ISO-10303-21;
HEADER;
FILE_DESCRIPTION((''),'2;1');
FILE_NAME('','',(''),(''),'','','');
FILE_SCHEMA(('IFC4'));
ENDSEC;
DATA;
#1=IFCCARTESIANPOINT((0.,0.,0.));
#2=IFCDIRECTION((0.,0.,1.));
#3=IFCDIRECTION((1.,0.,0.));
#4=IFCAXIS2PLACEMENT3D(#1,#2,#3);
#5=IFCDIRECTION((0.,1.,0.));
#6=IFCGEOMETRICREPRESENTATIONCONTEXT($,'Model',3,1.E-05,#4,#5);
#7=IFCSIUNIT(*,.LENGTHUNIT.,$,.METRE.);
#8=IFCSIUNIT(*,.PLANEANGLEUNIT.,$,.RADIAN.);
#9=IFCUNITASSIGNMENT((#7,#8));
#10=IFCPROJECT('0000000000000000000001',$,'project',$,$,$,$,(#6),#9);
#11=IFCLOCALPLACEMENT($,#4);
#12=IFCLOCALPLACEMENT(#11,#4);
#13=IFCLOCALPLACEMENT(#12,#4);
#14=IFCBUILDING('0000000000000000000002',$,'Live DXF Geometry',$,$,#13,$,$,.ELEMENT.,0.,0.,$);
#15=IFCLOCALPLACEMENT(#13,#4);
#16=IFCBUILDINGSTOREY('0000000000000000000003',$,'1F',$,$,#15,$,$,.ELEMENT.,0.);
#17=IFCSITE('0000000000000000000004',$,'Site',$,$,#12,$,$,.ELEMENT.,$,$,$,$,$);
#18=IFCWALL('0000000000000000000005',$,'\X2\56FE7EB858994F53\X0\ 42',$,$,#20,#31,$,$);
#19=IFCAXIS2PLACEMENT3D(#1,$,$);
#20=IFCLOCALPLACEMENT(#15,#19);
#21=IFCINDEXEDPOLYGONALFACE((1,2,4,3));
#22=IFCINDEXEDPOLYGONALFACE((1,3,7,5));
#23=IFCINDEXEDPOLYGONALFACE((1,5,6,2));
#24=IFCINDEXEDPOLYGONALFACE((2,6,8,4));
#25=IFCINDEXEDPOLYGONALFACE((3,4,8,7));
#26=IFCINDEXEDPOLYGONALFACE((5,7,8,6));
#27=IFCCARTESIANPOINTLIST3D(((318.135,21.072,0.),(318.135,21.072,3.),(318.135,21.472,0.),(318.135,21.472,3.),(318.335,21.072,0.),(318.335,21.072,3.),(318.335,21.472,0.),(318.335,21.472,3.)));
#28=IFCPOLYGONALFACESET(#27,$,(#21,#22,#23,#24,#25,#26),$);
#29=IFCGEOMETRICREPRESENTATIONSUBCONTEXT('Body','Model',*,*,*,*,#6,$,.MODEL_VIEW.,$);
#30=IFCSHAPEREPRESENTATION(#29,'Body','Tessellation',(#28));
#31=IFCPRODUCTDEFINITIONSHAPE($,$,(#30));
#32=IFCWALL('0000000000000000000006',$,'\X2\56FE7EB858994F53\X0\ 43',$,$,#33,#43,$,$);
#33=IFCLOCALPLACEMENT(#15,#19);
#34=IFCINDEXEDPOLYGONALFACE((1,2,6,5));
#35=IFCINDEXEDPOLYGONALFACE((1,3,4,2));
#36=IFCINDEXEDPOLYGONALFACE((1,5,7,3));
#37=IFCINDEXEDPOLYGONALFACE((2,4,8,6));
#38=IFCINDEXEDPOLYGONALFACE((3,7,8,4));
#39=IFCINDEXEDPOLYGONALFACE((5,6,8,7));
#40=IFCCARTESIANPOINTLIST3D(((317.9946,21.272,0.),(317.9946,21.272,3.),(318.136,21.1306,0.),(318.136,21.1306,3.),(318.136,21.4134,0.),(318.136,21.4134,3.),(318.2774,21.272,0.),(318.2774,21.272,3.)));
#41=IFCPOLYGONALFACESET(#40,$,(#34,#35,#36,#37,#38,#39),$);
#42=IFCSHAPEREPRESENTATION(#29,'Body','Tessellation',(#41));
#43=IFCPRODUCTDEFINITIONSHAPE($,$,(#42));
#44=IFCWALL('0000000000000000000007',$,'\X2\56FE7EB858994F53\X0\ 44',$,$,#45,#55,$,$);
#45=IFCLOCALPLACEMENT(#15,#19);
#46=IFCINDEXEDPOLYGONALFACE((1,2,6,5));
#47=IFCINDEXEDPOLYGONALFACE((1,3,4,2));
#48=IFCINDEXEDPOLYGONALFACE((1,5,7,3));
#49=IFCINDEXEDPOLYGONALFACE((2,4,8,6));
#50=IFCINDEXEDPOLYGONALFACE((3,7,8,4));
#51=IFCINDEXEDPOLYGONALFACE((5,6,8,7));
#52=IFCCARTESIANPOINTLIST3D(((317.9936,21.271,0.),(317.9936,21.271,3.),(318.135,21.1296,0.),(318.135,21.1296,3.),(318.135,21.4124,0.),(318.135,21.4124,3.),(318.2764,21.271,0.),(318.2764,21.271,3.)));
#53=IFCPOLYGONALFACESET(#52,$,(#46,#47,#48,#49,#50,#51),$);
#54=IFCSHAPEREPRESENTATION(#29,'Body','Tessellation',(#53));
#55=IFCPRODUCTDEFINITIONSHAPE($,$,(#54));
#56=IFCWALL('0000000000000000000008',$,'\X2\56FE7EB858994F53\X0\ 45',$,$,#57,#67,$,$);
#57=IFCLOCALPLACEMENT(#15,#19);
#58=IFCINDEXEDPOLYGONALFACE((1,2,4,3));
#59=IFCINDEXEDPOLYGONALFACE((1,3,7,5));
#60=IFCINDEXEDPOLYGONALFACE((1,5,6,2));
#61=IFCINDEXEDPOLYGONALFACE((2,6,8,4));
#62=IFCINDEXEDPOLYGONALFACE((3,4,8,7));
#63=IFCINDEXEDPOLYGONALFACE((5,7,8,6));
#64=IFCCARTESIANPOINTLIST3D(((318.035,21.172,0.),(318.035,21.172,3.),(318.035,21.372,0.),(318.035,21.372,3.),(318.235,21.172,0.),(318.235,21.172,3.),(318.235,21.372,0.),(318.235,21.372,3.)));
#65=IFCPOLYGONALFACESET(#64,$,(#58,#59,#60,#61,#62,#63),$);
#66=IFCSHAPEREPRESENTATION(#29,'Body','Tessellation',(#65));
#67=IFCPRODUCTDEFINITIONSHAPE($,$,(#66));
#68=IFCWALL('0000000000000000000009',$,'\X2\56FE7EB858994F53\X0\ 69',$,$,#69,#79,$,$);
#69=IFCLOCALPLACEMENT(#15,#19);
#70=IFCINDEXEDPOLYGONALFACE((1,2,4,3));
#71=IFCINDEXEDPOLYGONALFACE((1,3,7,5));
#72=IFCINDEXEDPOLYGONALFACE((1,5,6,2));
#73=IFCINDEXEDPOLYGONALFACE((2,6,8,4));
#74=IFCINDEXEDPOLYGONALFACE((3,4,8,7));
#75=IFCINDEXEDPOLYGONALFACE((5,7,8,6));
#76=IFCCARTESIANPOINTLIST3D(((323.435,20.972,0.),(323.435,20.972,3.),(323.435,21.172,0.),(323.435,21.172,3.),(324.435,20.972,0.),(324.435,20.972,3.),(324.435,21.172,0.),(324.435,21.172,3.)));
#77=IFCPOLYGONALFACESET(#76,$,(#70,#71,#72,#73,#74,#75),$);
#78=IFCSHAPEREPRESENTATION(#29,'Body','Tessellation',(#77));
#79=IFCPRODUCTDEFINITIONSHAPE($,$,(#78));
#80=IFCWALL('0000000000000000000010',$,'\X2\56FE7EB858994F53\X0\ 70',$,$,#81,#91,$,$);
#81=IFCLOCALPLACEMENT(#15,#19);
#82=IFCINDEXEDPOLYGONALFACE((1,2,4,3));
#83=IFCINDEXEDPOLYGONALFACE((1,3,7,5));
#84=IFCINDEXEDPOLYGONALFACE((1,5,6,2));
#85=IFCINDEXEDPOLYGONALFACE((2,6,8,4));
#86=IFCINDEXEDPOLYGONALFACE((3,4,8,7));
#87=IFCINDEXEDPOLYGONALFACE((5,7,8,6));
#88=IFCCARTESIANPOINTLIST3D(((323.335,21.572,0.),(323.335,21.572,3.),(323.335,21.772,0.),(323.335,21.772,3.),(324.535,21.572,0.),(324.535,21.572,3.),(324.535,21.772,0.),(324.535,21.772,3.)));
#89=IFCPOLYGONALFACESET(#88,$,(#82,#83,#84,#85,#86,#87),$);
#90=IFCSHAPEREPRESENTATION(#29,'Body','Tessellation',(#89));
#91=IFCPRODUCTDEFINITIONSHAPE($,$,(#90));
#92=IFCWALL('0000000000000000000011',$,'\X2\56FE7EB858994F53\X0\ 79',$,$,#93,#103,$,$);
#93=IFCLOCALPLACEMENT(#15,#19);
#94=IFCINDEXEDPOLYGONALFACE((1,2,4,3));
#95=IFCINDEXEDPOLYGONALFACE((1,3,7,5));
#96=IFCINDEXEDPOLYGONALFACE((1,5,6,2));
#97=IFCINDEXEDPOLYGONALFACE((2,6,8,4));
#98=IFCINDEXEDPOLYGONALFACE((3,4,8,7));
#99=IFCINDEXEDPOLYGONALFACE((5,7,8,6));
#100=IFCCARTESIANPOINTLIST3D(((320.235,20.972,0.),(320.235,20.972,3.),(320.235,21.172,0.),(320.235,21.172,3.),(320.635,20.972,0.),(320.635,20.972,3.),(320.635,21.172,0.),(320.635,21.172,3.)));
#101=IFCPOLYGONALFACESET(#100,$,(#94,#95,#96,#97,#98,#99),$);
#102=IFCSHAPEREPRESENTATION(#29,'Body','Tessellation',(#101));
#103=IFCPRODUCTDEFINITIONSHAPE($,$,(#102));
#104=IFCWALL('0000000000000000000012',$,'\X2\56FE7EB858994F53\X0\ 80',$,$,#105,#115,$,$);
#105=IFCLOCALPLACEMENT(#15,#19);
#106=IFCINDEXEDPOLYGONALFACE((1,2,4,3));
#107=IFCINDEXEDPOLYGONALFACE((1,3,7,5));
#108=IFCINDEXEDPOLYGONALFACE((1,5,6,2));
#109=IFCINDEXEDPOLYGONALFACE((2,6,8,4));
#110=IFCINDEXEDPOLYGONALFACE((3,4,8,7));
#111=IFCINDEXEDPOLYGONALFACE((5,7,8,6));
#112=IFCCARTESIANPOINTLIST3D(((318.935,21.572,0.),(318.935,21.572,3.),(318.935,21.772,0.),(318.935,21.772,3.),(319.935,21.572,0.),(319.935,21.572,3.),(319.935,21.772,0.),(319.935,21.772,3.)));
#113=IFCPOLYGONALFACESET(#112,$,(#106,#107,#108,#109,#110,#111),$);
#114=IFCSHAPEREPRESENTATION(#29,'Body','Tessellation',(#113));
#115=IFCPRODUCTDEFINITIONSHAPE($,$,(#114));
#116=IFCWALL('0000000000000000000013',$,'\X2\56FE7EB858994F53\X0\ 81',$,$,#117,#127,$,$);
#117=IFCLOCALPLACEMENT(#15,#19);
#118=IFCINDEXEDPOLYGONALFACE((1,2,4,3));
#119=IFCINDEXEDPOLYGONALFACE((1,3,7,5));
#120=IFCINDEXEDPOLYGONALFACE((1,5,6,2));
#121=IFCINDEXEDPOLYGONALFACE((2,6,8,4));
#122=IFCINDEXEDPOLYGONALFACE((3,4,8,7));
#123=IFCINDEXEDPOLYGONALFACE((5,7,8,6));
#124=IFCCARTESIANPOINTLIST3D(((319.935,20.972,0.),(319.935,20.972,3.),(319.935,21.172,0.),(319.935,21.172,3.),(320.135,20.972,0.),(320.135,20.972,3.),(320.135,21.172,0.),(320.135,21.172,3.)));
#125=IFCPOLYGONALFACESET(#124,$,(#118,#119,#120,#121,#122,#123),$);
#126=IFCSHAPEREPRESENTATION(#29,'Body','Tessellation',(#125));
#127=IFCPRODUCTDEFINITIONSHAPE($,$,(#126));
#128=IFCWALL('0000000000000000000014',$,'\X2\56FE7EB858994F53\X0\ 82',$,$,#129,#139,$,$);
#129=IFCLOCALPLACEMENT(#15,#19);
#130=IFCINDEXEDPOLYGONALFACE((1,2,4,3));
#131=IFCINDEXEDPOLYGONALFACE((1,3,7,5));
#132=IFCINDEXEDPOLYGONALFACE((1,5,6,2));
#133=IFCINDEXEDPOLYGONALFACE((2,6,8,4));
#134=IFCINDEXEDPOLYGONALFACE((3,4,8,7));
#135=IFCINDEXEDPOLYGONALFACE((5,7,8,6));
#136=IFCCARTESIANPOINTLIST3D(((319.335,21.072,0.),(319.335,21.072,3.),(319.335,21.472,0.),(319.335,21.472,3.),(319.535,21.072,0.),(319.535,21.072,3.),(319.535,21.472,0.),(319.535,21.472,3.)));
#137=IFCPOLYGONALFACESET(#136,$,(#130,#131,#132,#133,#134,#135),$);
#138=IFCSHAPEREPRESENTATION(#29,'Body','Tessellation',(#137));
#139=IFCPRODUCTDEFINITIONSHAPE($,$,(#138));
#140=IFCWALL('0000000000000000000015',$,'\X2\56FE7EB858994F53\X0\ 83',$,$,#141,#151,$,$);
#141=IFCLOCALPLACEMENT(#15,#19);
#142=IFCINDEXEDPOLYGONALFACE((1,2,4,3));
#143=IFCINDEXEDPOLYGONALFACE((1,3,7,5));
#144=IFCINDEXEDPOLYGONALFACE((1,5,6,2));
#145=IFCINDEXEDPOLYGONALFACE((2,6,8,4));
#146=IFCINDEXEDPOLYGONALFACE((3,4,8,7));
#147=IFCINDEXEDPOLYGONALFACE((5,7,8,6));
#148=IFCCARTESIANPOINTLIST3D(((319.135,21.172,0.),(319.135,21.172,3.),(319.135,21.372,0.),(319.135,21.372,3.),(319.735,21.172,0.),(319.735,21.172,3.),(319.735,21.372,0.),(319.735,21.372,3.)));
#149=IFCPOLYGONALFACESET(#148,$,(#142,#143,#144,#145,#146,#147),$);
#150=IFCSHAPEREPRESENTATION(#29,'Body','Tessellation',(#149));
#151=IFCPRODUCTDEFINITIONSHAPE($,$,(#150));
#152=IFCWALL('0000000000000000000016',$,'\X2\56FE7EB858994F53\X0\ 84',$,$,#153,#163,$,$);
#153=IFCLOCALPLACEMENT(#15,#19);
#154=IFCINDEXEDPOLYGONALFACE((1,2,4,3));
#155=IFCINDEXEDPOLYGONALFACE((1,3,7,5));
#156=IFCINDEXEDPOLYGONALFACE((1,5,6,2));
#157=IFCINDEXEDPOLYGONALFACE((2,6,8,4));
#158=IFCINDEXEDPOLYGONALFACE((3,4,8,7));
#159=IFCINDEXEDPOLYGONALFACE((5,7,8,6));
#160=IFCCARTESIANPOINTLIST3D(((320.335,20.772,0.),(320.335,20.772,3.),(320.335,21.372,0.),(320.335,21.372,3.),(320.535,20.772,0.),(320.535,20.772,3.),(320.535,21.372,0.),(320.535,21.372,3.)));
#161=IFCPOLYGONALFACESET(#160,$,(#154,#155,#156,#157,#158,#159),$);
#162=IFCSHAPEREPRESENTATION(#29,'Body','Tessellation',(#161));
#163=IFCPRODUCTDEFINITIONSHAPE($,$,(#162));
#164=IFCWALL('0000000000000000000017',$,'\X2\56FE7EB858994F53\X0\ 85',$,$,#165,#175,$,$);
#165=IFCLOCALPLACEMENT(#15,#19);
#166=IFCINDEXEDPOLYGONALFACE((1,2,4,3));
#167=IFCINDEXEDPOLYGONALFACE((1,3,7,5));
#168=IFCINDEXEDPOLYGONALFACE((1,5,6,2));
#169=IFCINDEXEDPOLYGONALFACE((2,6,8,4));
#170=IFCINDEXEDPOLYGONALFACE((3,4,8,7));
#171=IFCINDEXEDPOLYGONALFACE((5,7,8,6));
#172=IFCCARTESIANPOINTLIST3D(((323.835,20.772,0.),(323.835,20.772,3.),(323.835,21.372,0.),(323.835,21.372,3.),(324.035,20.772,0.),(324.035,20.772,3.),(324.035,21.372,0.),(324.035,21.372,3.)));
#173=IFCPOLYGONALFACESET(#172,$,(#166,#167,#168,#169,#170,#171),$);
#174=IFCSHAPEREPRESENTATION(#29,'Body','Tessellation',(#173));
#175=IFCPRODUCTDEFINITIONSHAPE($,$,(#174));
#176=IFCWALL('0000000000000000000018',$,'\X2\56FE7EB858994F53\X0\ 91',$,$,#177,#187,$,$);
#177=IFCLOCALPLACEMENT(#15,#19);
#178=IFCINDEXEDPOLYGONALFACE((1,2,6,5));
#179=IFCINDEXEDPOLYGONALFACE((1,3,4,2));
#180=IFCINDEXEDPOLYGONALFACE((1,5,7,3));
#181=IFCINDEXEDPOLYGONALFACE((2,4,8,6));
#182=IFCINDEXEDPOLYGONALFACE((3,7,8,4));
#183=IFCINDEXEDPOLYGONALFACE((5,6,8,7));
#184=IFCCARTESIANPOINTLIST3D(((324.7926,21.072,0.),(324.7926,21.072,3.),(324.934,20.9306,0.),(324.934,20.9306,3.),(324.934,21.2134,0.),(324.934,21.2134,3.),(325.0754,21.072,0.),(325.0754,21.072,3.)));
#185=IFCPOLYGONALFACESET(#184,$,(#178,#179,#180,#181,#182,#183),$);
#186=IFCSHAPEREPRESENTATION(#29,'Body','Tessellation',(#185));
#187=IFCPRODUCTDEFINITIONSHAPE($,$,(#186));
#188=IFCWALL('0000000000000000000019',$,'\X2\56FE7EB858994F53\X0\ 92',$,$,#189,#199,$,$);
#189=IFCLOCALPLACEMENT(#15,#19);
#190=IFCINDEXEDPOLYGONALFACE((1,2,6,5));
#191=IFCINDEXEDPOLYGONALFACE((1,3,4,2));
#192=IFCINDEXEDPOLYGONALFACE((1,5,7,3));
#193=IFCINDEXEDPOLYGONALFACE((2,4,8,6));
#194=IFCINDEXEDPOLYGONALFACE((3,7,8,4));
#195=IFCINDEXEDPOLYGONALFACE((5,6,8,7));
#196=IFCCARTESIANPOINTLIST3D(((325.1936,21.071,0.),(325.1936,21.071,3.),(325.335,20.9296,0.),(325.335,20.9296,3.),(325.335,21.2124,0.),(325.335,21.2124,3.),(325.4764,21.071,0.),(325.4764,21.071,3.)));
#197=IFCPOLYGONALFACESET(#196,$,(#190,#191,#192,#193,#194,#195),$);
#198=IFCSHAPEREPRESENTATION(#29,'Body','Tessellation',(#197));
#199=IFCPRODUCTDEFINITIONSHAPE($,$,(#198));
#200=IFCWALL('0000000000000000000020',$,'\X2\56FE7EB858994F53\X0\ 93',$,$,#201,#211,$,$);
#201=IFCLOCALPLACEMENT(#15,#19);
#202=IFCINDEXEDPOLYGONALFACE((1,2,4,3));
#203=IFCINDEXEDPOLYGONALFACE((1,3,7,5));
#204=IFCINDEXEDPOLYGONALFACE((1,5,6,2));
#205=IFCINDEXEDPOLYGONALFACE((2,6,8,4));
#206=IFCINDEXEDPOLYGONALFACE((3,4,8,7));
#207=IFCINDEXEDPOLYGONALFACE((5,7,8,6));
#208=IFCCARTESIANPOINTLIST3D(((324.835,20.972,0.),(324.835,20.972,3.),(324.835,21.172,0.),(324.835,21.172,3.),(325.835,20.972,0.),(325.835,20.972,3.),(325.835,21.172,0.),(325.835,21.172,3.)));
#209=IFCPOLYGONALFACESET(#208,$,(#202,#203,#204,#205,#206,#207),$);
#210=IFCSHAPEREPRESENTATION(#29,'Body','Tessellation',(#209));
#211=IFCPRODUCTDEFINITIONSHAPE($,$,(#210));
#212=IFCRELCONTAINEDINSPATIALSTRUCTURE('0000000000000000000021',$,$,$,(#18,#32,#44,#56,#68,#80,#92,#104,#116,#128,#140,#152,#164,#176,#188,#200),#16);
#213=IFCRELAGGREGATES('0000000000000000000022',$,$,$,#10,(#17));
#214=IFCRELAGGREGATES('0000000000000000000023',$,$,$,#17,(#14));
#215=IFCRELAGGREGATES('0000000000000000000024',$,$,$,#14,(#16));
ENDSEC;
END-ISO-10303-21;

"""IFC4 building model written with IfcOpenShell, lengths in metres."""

from ifc_helpers import new_model, si_unit, direction, frame, frame_2d, origin_with_axes, place, context, subcontext, project, spatial, rectangle, extrude, element, save


model = new_model("IFC4")

# Units and contexts
model_context = context("Model", 3, precision=1e-05, world=origin_with_axes(), true_north=direction((0.0, 1.0, 0.0)))
body_context = subcontext(model_context, "Body", "Model", "MODEL_VIEW")
ifc_project = project(units=[si_unit("LENGTHUNIT", "METRE"), si_unit("PLANEANGLEUNIT", "RADIAN")], contexts=[model_context])

# Site, building, storey
placement = place(None, origin_with_axes())
site_placement = place(placement, origin_with_axes())
site = spatial("IfcSite", under=ifc_project, at=site_placement, Name="Site", CompositionType="ELEMENT")
building_placement = place(site_placement, origin_with_axes())
building = spatial("IfcBuilding", under=site, at=building_placement, Name="Live DXF Geometry", CompositionType="ELEMENT", ElevationOfRefHeight=0.0, ElevationOfTerrain=0.0)
storey_placement = place(building_placement, origin_with_axes())
storey = spatial("IfcBuildingStorey", under=building, at=storey_placement, Name="1F", CompositionType="ELEMENT", Elevation=0.0)

# Walls
wall_1_placement = place(storey_placement, frame((318.235, 21.272, 0.0), z_axis=(0.0, 0.0, 1.0), x_axis=(0.0, 1.0, 0.0)))
element("IfcWall", 1, at=wall_1_placement, inside=storey, Name="图纸墙体 42", context=body_context, shape_type="SweptSolid", body=[
    extrude(rectangle(XDim=0.4, YDim=0.2, at=frame_2d((0.0, 0.0), x_axis=(1.0, 0.0, 0.0))), frame((0.0, 0.0, 0.0), z_axis=(0.0, 0.0, 1.0)), (0.0, 0.0, 1.0), 3.0),
])
for number, where, z_axis, x_axis, name in (
    (2, (318.136, 21.272, 0.0), (0.0, 0.0, 1.0), (-0.707107, -0.707107, 0.0), "图纸墙体 43"),
    (3, (318.135, 21.271, 0.0), (0.0, 0.0, 1.0), (0.707107, 0.707107, 0.0), "图纸墙体 44"),
    (4, (318.135, 21.272, 0.0), (0.0, 0.0, 1.0), (1.0, 0.0, 0.0), "图纸墙体 45"),
):
    element("IfcWall", number, at=place(storey_placement, frame(where, z_axis=z_axis, x_axis=x_axis)), inside=storey, Name=name, context=body_context, shape_type="SweptSolid", body=[
        extrude(rectangle(XDim=0.2, YDim=0.2, at=frame_2d((0.0, 0.0), x_axis=(1.0, 0.0, 0.0))), frame((0.0, 0.0, 0.0), z_axis=(0.0, 0.0, 1.0)), (0.0, 0.0, 1.0), 3.0),
    ])
wall_2_placement = place(storey_placement, frame((323.935, 21.072, 0.0), z_axis=(0.0, 0.0, 1.0), x_axis=(1.0, 0.0, 0.0)))
element("IfcWall", 5, at=wall_2_placement, inside=storey, Name="图纸墙体 69", context=body_context, shape_type="SweptSolid", body=[
    extrude(rectangle(XDim=1.0, YDim=0.2, at=frame_2d((0.0, 0.0), x_axis=(1.0, 0.0, 0.0))), frame((0.0, 0.0, 0.0), z_axis=(0.0, 0.0, 1.0)), (0.0, 0.0, 1.0), 3.0),
])
wall_3_placement = place(storey_placement, frame((323.935, 21.672, 0.0), z_axis=(0.0, 0.0, 1.0), x_axis=(1.0, 0.0, 0.0)))
element("IfcWall", 6, at=wall_3_placement, inside=storey, Name="图纸墙体 70", context=body_context, shape_type="SweptSolid", body=[
    extrude(rectangle(XDim=1.2, YDim=0.2, at=frame_2d((0.0, 0.0), x_axis=(1.0, 0.0, 0.0))), frame((0.0, 0.0, 0.0), z_axis=(0.0, 0.0, 1.0)), (0.0, 0.0, 1.0), 3.0),
])
wall_4_placement = place(storey_placement, frame((320.435, 21.072, 0.0), z_axis=(0.0, 0.0, 1.0), x_axis=(-1.0, 0.0, 0.0)))
element("IfcWall", 7, at=wall_4_placement, inside=storey, Name="图纸墙体 79", context=body_context, shape_type="SweptSolid", body=[
    extrude(rectangle(XDim=0.4, YDim=0.2, at=frame_2d((0.0, 0.0), x_axis=(1.0, 0.0, 0.0))), frame((0.0, 0.0, 0.0), z_axis=(0.0, 0.0, 1.0)), (0.0, 0.0, 1.0), 3.0),
])
wall_5_placement = place(storey_placement, frame((319.435, 21.672, 0.0), z_axis=(0.0, 0.0, 1.0), x_axis=(1.0, 0.0, 0.0)))
element("IfcWall", 8, at=wall_5_placement, inside=storey, Name="图纸墙体 80", context=body_context, shape_type="SweptSolid", body=[
    extrude(rectangle(XDim=1.0, YDim=0.2, at=frame_2d((0.0, 0.0), x_axis=(1.0, 0.0, 0.0))), frame((0.0, 0.0, 0.0), z_axis=(0.0, 0.0, 1.0)), (0.0, 0.0, 1.0), 3.0),
])
wall_6_placement = place(storey_placement, frame((320.035, 21.072, 0.0), z_axis=(0.0, 0.0, 1.0), x_axis=(0.0, 1.0, 0.0)))
element("IfcWall", 9, at=wall_6_placement, inside=storey, Name="图纸墙体 81", context=body_context, shape_type="SweptSolid", body=[
    extrude(rectangle(XDim=0.2, YDim=0.2, at=frame_2d((0.0, 0.0), x_axis=(1.0, 0.0, 0.0))), frame((0.0, 0.0, 0.0), z_axis=(0.0, 0.0, 1.0)), (0.0, 0.0, 1.0), 3.0),
])
wall_7_placement = place(storey_placement, frame((319.435, 21.272, 0.0), z_axis=(0.0, 0.0, 1.0), x_axis=(0.0, 1.0, 0.0)))
element("IfcWall", 10, at=wall_7_placement, inside=storey, Name="图纸墙体 82", context=body_context, shape_type="SweptSolid", body=[
    extrude(rectangle(XDim=0.4, YDim=0.2, at=frame_2d((0.0, 0.0), x_axis=(1.0, 0.0, 0.0))), frame((0.0, 0.0, 0.0), z_axis=(0.0, 0.0, 1.0)), (0.0, 0.0, 1.0), 3.0),
])
for number, where, z_axis, x_axis, name in (
    (11, (319.435, 21.272, 0.0), (0.0, 0.0, 1.0), (1.0, 0.0, 0.0), "图纸墙体 83"),
    (12, (320.435, 21.072, 0.0), (0.0, 0.0, 1.0), (0.0, 1.0, 0.0), "图纸墙体 84"),
    (13, (323.935, 21.072, 0.0), (0.0, 0.0, 1.0), (0.0, 1.0, 0.0), "图纸墙体 85"),
):
    element("IfcWall", number, at=place(storey_placement, frame(where, z_axis=z_axis, x_axis=x_axis)), inside=storey, Name=name, context=body_context, shape_type="SweptSolid", body=[
        extrude(rectangle(XDim=0.6, YDim=0.2, at=frame_2d((0.0, 0.0), x_axis=(1.0, 0.0, 0.0))), frame((0.0, 0.0, 0.0), z_axis=(0.0, 0.0, 1.0)), (0.0, 0.0, 1.0), 3.0),
    ])
for number, where, z_axis, x_axis, name in (
    (14, (324.934, 21.072, 0.0), (0.0, 0.0, 1.0), (0.707107, -0.707107, 0.0), "图纸墙体 91"),
    (15, (325.335, 21.071, 0.0), (0.0, 0.0, 1.0), (0.707107, 0.707107, 0.0), "图纸墙体 92"),
):
    element("IfcWall", number, at=place(storey_placement, frame(where, z_axis=z_axis, x_axis=x_axis)), inside=storey, Name=name, context=body_context, shape_type="SweptSolid", body=[
        extrude(rectangle(XDim=0.2, YDim=0.2, at=frame_2d((0.0, 0.0), x_axis=(1.0, 0.0, 0.0))), frame((0.0, 0.0, 0.0), z_axis=(0.0, 0.0, 1.0)), (0.0, 0.0, 1.0), 3.0),
    ])
wall_8_placement = place(storey_placement, frame((325.335, 21.072, 0.0), z_axis=(0.0, 0.0, 1.0), x_axis=(1.0, 0.0, 0.0)))
element("IfcWall", 16, at=wall_8_placement, inside=storey, Name="图纸墙体 93", context=body_context, shape_type="SweptSolid", body=[
    extrude(rectangle(XDim=1.0, YDim=0.2, at=frame_2d((0.0, 0.0), x_axis=(1.0, 0.0, 0.0))), frame((0.0, 0.0, 0.0), z_axis=(0.0, 0.0, 1.0)), (0.0, 0.0, 1.0), 3.0),
])

save(model, "model.ifc")
